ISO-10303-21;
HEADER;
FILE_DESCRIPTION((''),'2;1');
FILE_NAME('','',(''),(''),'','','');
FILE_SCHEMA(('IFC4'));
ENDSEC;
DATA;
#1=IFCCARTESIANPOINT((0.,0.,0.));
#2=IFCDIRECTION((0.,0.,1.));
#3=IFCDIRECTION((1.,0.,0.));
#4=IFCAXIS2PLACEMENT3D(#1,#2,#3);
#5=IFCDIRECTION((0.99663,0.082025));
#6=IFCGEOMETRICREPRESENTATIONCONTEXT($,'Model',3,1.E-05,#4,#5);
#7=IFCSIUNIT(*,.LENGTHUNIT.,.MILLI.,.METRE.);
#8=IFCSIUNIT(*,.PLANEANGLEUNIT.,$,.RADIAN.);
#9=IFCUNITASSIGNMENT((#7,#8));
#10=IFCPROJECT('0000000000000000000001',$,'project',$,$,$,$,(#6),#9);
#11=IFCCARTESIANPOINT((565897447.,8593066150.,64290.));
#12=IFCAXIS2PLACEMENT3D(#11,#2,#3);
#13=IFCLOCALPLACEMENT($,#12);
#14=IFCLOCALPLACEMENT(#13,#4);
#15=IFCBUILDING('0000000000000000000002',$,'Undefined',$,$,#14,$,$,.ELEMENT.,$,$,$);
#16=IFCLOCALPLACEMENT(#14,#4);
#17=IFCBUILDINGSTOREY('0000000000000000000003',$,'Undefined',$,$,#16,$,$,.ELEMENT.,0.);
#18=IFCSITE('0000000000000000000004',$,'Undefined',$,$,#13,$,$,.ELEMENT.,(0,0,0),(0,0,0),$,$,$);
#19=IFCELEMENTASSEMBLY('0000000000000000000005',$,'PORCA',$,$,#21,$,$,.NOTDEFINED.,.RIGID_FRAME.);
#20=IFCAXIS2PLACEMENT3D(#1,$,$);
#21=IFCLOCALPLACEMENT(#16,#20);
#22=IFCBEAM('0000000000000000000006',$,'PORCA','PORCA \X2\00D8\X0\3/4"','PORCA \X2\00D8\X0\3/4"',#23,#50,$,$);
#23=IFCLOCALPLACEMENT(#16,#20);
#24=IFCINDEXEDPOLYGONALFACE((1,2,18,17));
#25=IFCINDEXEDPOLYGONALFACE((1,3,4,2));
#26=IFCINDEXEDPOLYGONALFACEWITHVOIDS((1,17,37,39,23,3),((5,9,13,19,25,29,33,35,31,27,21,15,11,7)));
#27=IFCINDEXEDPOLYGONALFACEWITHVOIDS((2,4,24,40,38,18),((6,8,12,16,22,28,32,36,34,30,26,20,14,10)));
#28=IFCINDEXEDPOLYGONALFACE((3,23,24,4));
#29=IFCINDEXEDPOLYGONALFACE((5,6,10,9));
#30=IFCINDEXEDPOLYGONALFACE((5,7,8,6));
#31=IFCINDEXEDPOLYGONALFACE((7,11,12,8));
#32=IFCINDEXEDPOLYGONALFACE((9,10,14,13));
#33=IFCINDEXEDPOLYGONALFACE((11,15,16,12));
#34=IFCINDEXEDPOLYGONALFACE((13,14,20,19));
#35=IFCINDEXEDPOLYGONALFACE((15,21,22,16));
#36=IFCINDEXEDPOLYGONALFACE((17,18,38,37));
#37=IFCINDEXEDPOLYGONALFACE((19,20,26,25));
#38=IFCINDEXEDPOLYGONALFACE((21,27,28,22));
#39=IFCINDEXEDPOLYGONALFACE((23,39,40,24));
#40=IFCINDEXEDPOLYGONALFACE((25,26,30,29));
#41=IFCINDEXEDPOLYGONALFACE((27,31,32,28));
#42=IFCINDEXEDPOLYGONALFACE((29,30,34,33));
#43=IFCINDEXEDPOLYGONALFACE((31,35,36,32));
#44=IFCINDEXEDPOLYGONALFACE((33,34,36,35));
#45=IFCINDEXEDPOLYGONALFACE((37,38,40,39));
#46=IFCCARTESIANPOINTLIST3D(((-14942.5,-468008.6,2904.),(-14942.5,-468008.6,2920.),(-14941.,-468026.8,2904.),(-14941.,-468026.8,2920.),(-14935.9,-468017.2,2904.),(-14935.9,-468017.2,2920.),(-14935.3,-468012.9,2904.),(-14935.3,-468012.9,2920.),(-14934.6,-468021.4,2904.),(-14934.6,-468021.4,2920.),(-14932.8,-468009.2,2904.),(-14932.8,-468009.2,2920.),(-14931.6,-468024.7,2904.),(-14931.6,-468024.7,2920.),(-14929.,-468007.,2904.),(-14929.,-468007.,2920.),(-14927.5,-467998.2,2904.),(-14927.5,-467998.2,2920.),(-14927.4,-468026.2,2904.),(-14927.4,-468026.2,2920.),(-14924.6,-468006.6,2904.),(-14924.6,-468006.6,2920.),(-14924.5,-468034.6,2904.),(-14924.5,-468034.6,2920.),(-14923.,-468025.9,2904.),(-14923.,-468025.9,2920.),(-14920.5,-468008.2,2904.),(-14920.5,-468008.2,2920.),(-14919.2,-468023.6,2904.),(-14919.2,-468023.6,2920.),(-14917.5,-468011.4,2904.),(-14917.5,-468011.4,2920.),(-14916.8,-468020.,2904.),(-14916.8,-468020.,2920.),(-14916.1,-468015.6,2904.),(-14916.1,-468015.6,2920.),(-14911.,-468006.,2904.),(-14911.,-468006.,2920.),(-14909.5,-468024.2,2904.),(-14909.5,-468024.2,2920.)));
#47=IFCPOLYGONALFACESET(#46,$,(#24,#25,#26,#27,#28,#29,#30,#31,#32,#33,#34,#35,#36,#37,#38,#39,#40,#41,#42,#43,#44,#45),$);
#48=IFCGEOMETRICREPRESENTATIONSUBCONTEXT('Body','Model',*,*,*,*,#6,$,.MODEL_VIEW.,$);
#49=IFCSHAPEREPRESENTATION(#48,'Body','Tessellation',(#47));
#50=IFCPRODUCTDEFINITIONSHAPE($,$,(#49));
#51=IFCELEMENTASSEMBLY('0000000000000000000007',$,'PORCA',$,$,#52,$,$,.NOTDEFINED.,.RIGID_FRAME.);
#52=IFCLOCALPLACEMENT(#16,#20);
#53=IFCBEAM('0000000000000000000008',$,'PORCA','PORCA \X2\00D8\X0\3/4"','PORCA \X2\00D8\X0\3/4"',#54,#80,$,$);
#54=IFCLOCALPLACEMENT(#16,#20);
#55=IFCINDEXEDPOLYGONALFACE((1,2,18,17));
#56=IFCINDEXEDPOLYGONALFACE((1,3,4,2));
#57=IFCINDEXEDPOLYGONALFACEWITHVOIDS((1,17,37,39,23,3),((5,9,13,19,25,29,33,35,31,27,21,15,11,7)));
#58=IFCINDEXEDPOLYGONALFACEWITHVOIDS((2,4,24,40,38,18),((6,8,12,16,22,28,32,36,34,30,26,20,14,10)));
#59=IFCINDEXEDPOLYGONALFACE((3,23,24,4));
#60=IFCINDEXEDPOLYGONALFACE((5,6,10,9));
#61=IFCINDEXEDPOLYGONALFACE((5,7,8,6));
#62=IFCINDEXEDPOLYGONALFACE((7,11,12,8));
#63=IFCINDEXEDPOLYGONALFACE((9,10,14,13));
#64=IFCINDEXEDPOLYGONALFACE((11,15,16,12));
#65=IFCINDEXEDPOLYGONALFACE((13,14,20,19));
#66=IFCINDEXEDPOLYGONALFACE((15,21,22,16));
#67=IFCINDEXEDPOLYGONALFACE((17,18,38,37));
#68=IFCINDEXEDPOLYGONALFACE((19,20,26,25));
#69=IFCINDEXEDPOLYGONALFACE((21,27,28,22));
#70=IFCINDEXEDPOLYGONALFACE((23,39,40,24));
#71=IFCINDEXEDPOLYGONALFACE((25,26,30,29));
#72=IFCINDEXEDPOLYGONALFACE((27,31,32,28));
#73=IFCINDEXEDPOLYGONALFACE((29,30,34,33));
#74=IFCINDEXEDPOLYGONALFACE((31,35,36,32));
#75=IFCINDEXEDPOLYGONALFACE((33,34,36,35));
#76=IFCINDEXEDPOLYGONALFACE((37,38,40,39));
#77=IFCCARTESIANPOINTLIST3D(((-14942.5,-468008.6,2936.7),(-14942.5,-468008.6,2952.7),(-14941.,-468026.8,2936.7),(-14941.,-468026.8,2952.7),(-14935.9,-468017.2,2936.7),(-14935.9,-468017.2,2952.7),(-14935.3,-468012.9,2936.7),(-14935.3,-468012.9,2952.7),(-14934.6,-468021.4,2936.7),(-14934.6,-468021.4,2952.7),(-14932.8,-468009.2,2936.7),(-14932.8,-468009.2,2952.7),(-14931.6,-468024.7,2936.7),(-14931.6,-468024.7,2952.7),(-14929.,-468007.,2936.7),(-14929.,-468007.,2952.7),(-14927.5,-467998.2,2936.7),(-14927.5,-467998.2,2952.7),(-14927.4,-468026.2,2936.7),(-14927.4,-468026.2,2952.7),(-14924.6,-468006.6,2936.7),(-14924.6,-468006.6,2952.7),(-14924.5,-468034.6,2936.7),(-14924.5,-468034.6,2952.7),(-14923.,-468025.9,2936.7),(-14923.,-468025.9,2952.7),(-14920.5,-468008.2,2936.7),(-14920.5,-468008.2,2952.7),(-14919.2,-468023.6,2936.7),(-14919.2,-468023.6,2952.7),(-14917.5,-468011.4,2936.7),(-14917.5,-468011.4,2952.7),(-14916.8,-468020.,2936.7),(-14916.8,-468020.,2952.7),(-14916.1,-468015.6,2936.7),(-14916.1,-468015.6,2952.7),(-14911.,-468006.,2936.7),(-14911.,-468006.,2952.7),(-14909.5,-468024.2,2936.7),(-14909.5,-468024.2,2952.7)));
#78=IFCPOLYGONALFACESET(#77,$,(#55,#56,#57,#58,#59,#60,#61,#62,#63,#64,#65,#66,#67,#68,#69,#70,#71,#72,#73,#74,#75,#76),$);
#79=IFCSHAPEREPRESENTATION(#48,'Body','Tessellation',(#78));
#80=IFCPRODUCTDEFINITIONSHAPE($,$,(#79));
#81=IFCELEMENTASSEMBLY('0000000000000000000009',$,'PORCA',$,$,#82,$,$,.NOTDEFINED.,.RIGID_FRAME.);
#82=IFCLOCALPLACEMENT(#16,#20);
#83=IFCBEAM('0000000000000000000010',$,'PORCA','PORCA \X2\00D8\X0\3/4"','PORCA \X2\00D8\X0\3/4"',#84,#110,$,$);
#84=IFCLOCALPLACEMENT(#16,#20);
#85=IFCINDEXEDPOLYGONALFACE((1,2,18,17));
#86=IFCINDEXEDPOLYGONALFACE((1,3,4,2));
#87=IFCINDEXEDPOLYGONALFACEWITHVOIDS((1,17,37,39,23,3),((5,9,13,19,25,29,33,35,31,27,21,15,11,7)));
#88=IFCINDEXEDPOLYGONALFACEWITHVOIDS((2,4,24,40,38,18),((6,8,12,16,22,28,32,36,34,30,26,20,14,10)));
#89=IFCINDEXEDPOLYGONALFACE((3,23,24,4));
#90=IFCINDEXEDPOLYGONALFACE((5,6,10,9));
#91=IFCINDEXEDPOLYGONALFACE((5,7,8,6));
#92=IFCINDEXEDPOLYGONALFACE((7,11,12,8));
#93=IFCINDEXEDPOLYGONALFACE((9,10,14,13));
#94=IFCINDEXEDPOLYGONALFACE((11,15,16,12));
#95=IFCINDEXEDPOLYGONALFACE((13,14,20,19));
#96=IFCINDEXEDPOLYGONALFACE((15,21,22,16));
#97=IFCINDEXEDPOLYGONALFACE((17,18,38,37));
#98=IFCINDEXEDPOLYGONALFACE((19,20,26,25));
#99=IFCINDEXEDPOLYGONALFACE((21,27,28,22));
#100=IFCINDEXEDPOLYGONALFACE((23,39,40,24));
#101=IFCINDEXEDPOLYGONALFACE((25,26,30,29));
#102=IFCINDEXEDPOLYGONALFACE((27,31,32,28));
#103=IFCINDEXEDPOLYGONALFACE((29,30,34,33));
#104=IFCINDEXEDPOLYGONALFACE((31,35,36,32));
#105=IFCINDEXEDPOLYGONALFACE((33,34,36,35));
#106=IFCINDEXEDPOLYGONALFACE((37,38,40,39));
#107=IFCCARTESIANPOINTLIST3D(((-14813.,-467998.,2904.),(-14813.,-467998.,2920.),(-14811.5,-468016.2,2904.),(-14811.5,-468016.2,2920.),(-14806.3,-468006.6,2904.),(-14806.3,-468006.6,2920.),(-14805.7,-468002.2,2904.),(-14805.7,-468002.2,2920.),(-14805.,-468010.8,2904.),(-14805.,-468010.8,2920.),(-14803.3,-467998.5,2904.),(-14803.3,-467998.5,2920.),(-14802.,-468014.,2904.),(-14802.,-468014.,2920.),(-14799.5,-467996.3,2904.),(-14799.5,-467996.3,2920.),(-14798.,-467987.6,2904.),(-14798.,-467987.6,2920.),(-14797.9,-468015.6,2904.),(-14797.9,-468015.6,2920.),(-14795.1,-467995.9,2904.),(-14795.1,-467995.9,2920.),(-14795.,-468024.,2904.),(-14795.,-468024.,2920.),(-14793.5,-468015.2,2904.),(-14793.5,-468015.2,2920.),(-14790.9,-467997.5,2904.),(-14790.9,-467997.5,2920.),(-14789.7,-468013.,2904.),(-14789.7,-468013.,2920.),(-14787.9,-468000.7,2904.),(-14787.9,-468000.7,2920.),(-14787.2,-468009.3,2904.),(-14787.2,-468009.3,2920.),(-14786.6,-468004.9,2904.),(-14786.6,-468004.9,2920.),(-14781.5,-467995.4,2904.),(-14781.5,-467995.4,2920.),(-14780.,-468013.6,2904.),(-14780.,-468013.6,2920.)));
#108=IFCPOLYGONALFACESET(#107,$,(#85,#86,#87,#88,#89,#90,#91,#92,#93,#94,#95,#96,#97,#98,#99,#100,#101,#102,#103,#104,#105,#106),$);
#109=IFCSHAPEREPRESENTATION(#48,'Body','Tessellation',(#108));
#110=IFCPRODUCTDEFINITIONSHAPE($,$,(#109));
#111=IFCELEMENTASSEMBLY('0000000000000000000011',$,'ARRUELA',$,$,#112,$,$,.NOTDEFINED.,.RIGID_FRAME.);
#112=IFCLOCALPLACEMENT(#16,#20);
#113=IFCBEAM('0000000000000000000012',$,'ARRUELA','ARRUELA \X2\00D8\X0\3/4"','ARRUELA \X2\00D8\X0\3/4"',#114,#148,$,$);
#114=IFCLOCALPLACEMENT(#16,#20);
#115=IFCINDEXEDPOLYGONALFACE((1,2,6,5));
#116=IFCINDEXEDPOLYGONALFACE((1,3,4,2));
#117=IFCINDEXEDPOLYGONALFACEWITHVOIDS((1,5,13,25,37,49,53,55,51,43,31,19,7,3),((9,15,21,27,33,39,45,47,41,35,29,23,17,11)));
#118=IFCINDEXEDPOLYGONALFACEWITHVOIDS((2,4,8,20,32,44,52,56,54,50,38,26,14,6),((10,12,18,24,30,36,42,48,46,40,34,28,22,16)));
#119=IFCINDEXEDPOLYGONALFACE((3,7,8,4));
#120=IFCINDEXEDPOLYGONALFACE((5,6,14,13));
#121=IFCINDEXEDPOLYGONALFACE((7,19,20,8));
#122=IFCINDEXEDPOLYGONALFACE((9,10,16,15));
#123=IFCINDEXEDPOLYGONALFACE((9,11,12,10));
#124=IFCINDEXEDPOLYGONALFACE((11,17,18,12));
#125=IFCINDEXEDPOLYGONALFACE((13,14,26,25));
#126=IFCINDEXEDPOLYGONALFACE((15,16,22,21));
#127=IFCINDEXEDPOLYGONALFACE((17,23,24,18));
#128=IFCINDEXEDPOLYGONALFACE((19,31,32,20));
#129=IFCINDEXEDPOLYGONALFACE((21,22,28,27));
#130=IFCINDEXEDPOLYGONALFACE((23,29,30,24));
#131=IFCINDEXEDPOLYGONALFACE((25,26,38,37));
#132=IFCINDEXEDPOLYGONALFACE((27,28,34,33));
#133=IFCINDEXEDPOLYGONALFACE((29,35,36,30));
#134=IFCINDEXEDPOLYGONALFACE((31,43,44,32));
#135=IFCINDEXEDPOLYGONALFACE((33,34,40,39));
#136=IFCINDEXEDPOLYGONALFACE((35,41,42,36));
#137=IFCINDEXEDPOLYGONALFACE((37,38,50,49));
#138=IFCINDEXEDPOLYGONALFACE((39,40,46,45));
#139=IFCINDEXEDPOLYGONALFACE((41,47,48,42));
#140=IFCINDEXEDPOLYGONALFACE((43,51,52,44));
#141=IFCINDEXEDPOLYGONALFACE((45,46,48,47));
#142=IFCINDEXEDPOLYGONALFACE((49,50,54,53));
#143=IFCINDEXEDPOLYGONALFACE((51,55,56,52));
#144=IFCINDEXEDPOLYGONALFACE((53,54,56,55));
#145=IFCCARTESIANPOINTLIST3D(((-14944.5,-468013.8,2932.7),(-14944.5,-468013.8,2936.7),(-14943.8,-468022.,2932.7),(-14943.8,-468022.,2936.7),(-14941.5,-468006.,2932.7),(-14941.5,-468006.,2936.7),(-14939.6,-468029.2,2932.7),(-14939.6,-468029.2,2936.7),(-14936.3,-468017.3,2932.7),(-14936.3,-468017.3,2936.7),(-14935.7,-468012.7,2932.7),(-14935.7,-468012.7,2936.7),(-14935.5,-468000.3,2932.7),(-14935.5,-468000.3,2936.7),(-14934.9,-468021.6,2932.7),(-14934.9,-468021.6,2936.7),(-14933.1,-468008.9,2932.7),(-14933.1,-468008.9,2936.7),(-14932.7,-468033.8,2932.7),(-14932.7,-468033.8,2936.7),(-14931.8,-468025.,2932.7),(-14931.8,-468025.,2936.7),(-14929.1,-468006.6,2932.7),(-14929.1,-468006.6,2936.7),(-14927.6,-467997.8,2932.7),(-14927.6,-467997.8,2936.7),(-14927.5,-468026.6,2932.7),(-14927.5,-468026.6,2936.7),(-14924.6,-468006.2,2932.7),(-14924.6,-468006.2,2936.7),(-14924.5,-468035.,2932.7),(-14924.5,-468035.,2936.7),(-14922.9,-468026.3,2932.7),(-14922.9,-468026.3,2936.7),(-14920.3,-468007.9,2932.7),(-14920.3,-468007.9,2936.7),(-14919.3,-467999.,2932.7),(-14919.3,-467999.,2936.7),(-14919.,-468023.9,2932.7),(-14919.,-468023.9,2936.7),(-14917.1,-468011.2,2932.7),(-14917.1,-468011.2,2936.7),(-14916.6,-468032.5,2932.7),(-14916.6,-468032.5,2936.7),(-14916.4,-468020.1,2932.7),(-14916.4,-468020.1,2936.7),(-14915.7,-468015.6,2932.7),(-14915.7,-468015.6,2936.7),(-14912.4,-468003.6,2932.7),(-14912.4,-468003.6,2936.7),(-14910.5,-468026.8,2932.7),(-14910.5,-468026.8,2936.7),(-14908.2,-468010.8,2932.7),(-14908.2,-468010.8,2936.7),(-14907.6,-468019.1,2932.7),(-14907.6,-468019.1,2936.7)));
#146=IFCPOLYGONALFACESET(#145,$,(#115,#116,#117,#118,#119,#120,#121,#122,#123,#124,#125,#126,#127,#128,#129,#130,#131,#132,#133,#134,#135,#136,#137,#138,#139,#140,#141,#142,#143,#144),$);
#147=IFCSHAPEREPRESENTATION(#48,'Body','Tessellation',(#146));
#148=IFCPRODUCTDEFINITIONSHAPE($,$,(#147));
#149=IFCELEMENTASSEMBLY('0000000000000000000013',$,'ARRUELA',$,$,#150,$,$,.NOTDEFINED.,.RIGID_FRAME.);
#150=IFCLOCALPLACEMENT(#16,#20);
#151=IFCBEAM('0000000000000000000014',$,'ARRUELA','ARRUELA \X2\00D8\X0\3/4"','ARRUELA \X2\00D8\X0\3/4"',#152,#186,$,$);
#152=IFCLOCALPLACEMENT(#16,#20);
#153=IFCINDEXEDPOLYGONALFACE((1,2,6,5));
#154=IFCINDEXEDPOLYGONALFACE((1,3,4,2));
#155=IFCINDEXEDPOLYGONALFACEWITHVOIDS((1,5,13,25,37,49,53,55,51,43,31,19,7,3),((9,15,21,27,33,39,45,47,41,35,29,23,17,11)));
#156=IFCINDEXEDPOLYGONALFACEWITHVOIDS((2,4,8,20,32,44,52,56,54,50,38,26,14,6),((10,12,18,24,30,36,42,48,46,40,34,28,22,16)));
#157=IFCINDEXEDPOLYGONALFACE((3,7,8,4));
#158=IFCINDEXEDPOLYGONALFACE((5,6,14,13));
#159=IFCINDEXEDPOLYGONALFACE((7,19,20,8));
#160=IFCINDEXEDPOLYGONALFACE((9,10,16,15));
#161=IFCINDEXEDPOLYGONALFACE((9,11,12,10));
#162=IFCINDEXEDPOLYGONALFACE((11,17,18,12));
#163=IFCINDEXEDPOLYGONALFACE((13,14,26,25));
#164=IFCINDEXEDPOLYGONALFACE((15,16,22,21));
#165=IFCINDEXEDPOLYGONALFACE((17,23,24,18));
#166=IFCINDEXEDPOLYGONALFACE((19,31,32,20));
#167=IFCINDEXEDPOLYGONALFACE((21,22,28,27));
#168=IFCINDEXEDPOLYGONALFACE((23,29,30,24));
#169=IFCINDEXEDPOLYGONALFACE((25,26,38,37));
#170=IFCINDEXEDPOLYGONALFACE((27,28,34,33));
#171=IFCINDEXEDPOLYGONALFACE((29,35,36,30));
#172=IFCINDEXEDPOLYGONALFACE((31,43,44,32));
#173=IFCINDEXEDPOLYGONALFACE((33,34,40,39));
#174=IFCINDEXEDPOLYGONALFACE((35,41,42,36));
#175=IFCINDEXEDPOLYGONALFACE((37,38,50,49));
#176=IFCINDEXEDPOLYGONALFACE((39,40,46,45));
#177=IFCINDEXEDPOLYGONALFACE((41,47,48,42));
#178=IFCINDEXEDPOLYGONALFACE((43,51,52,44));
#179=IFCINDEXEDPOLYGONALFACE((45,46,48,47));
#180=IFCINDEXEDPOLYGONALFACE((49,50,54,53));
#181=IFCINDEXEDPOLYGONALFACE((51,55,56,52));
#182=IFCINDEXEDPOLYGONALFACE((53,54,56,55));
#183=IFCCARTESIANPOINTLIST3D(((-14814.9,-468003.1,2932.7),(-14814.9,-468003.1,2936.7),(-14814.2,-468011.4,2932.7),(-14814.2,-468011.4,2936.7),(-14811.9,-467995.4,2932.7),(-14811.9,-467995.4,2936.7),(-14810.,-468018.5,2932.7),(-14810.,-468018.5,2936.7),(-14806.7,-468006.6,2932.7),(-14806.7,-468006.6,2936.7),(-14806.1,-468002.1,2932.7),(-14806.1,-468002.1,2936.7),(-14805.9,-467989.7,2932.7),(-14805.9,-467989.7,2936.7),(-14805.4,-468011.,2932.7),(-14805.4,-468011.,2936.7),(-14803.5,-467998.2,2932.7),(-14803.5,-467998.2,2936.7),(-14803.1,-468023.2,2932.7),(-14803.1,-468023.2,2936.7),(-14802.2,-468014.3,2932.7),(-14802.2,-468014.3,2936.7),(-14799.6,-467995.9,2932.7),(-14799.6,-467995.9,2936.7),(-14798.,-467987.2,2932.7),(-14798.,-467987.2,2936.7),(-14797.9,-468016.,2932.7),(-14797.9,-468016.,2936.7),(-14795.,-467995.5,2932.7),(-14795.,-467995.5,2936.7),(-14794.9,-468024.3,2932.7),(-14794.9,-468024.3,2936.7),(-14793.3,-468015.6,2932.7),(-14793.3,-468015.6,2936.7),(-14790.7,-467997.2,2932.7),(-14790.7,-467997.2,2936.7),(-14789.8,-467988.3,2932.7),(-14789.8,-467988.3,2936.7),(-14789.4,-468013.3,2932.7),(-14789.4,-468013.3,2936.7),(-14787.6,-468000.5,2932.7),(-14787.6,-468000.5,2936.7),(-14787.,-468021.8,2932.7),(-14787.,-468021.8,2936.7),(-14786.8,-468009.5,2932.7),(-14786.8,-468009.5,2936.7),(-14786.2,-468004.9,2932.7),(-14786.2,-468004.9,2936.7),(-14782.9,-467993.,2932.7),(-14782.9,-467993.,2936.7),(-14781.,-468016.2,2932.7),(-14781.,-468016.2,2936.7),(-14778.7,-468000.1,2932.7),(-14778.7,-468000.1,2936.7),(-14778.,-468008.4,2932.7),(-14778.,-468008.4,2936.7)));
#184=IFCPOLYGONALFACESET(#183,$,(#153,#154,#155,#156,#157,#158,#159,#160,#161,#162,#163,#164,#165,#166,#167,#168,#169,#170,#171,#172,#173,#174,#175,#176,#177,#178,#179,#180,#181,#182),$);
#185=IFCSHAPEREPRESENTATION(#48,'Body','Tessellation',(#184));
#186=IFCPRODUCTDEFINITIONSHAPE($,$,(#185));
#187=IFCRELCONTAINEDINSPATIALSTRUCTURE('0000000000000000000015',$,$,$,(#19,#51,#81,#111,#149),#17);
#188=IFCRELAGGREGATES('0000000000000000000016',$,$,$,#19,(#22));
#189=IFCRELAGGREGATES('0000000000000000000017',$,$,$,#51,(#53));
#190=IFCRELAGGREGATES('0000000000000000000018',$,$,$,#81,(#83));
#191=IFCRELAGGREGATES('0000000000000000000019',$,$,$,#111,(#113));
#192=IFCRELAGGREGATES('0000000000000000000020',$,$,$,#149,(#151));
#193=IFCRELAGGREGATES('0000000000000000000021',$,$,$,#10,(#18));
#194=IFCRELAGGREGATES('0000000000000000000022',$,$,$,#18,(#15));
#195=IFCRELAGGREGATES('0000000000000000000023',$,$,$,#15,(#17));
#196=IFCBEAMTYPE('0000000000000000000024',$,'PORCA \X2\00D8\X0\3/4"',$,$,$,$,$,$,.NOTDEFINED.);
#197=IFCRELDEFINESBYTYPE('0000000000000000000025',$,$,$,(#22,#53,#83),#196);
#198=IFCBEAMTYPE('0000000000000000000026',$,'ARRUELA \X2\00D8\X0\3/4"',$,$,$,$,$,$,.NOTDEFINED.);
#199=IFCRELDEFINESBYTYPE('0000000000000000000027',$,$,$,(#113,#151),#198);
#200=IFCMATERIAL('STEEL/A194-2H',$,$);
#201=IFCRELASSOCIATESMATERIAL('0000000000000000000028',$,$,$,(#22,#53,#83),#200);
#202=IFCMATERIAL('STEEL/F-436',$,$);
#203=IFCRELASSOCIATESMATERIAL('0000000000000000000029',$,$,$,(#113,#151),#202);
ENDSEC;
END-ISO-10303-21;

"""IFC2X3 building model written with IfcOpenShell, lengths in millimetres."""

from ifc_helpers import new_model, si_unit, direction, frame, origin_with_axes, place, context, subcontext, project, spatial, polyline, outline, extrude, material, type_object, element, aggregate, save


model = new_model("IFC2X3")

# Units and contexts
model_context = context("Model", 3, precision=1e-05, world=origin_with_axes(), true_north=direction((0.99663, 0.082025)))
body_context = subcontext(model_context, "Body", "Model", "MODEL_VIEW")
ifc_project = project(units=[si_unit("LENGTHUNIT", "METRE", prefix="MILLI"), si_unit("PLANEANGLEUNIT", "RADIAN")], contexts=[model_context])

# Site, building, storey
site_placement = place(None, frame((565897447.0, 8593066150.0, 64290.0), z_axis=(0.0, 0.0, 1.0), x_axis=(1.0, 0.0, 0.0)))
site = spatial("IfcSite", under=ifc_project, at=site_placement, Name="Undefined", CompositionType="ELEMENT", RefLatitude=(0, 0, 0), RefLongitude=(0, 0, 0))
building_placement = place(site_placement, origin_with_axes())
building = spatial("IfcBuilding", under=site, at=building_placement, Name="Undefined", CompositionType="ELEMENT")
storey_placement = place(building_placement, origin_with_axes())
storey = spatial("IfcBuildingStorey", under=building, at=storey_placement, Name="Undefined", CompositionType="ELEMENT", Elevation=0.0)

# Element assemblies, beams
assembly_1_placement = place(storey_placement, origin_with_axes())
assembly_1 = element("IfcElementAssembly", 1, at=assembly_1_placement, inside=storey, Name="PORCA", AssemblyPlace="NOTDEFINED", PredefinedType="RIGID_FRAME")
ifc_material_1 = material(Name="STEEL/A194-2H")
beam_type_1 = type_object("IfcBeamType", Name="PORCA Ø3/4\"", PredefinedType="NOTDEFINED")
beam_1_placement = place(assembly_1_placement, frame((-14926.0, -468016.4, 2920.0), z_axis=(0.99663, 0.082025, 0.0), x_axis=(0.0, 0.0, -1.0)))
beam_1 = element("IfcBeam", 2, at=beam_1_placement, type_object=beam_type_1, material=ifc_material_1, Name="PORCA", Description="PORCA Ø3/4\"", ObjectType="PORCA Ø3/4\"", context=body_context, shape_type="SweptSolid", body=[
    extrude(outline(polyline([(-9.1, 15.8), (9.1, 15.8), (18.3, 0.0), (9.1, -15.8), (-9.1, -15.8), (-18.3, 0.0), (-9.1, 15.8)]), holes=[polyline([(7.8, -6.2), (9.7, -2.2), (9.7, 2.2), (7.8, 6.2), (4.3, 8.9), (0.0, 9.9), (-4.3, 8.9), (-7.8, 6.2), (-9.7, 2.2), (-9.7, -2.2), (-7.8, -6.2), (-4.3, -8.9), (0.0, -9.9), (4.3, -8.9), (7.8, -6.2)])]), frame((16.0, 0.0, 0.0), z_axis=(-1.0, 0.0, 0.0), x_axis=(0.0, -1.0, 0.0)), (0.0, 0.0, 1.0), 16.0),
])
aggregate(assembly_1, [beam_1])
assembly_2_placement = place(storey_placement, origin_with_axes())
assembly_2 = element("IfcElementAssembly", 3, at=assembly_2_placement, inside=storey, Name="PORCA", AssemblyPlace="NOTDEFINED", PredefinedType="RIGID_FRAME")
beam_2_placement = place(assembly_2_placement, frame((-14926.0, -468016.4, 2952.7), z_axis=(0.99663, 0.082025, 0.0), x_axis=(0.0, 0.0, -1.0)))
beam_2 = element("IfcBeam", 4, at=beam_2_placement, type_object=beam_type_1, material=ifc_material_1, Name="PORCA", Description="PORCA Ø3/4\"", ObjectType="PORCA Ø3/4\"", context=body_context, shape_type="SweptSolid", body=[
    extrude(outline(polyline([(-9.1, 15.8), (9.1, 15.8), (18.3, 0.0), (9.1, -15.8), (-9.1, -15.8), (-18.3, 0.0), (-9.1, 15.8)]), holes=[polyline([(7.8, -6.2), (9.7, -2.2), (9.7, 2.2), (7.8, 6.2), (4.3, 8.9), (0.0, 9.9), (-4.3, 8.9), (-7.8, 6.2), (-9.7, 2.2), (-9.7, -2.2), (-7.8, -6.2), (-4.3, -8.9), (0.0, -9.9), (4.3, -8.9), (7.8, -6.2)])]), frame((16.0, 0.0, 0.0), z_axis=(-1.0, 0.0, 0.0), x_axis=(0.0, -1.0, 0.0)), (0.0, 0.0, 1.0), 16.0),
])
aggregate(assembly_2, [beam_2])
assembly_3_placement = place(storey_placement, origin_with_axes())
assembly_3 = element("IfcElementAssembly", 5, at=assembly_3_placement, inside=storey, Name="PORCA", AssemblyPlace="NOTDEFINED", PredefinedType="RIGID_FRAME")
beam_3_placement = place(assembly_3_placement, frame((-14796.5, -468005.8, 2920.0), z_axis=(-0.99663, -0.082025, 0.0), x_axis=(0.0, 0.0, -1.0)))
beam_3 = element("IfcBeam", 6, at=beam_3_placement, type_object=beam_type_1, material=ifc_material_1, Name="PORCA", Description="PORCA Ø3/4\"", ObjectType="PORCA Ø3/4\"", context=body_context, shape_type="SweptSolid", body=[
    extrude(outline(polyline([(-9.1, 15.8), (9.1, 15.8), (18.3, 0.0), (9.1, -15.8), (-9.1, -15.8), (-18.3, 0.0), (-9.1, 15.8)]), holes=[polyline([(7.8, -6.2), (9.7, -2.2), (9.7, 2.2), (7.8, 6.2), (4.3, 8.9), (0.0, 9.9), (-4.3, 8.9), (-7.8, 6.2), (-9.7, 2.2), (-9.7, -2.2), (-7.8, -6.2), (-4.3, -8.9), (0.0, -9.9), (4.3, -8.9), (7.8, -6.2)])]), frame((16.0, 0.0, 0.0), z_axis=(-1.0, 0.0, 0.0), x_axis=(0.0, -1.0, 0.0)), (0.0, 0.0, 1.0), 16.0),
])
aggregate(assembly_3, [beam_3])
assembly_4_placement = place(storey_placement, origin_with_axes())
assembly_4 = element("IfcElementAssembly", 7, at=assembly_4_placement, inside=storey, Name="ARRUELA", AssemblyPlace="NOTDEFINED", PredefinedType="RIGID_FRAME")
ifc_material_2 = material(Name="STEEL/F-436")
beam_type_2 = type_object("IfcBeamType", Name="ARRUELA Ø3/4\"", PredefinedType="NOTDEFINED")
beam_4_placement = place(assembly_4_placement, frame((-14926.0, -468016.4, 2936.7), z_axis=(0.99663, 0.082025, 0.0), x_axis=(0.0, 0.0, -1.0)))
beam_4 = element("IfcBeam", 8, at=beam_4_placement, type_object=beam_type_2, material=ifc_material_2, Name="ARRUELA", Description="ARRUELA Ø3/4\"", ObjectType="ARRUELA Ø3/4\"", context=body_context, shape_type="SweptSolid", body=[
    extrude(outline(polyline([(11.6, 14.6), (16.8, 8.1), (18.6, 0.0), (16.8, -8.1), (11.6, -14.6), (4.2, -18.2), (-4.2, -18.2), (-11.6, -14.6), (-16.8, -8.1), (-18.6, 0.0), (-16.8, 8.1), (-11.6, 14.6), (-4.2, 18.2), (4.2, 18.2), (11.6, 14.6)]), holes=[polyline([(8.1, -6.4), (10.1, -2.3), (10.1, 2.3), (8.1, 6.4), (4.5, 9.3), (0.0, 10.3), (-4.5, 9.3), (-8.1, 6.4), (-10.1, 2.3), (-10.1, -2.3), (-8.1, -6.4), (-4.5, -9.3), (0.0, -10.3), (4.5, -9.3), (8.1, -6.4)])]), frame((4.0, 0.0, 0.0), z_axis=(-1.0, 0.0, 0.0), x_axis=(0.0, -1.0, 0.0)), (0.0, 0.0, 1.0), 4.0),
])
aggregate(assembly_4, [beam_4])
assembly_5_placement = place(storey_placement, origin_with_axes())
assembly_5 = element("IfcElementAssembly", 9, at=assembly_5_placement, inside=storey, Name="ARRUELA", AssemblyPlace="NOTDEFINED", PredefinedType="RIGID_FRAME")
beam_5_placement = place(assembly_5_placement, frame((-14796.5, -468005.8, 2936.7), z_axis=(-0.99663, -0.082025, 0.0), x_axis=(0.0, 0.0, -1.0)))
beam_5 = element("IfcBeam", 10, at=beam_5_placement, type_object=beam_type_2, material=ifc_material_2, Name="ARRUELA", Description="ARRUELA Ø3/4\"", ObjectType="ARRUELA Ø3/4\"", context=body_context, shape_type="SweptSolid", body=[
    extrude(outline(polyline([(11.6, 14.6), (16.8, 8.1), (18.6, 0.0), (16.8, -8.1), (11.6, -14.6), (4.2, -18.2), (-4.2, -18.2), (-11.6, -14.6), (-16.8, -8.1), (-18.6, 0.0), (-16.8, 8.1), (-11.6, 14.6), (-4.2, 18.2), (4.2, 18.2), (11.6, 14.6)]), holes=[polyline([(8.1, -6.4), (10.1, -2.3), (10.1, 2.3), (8.1, 6.4), (4.5, 9.3), (0.0, 10.3), (-4.5, 9.3), (-8.1, 6.4), (-10.1, 2.3), (-10.1, -2.3), (-8.1, -6.4), (-4.5, -9.3), (0.0, -10.3), (4.5, -9.3), (8.1, -6.4)])]), frame((4.0, 0.0, 0.0), z_axis=(-1.0, 0.0, 0.0), x_axis=(0.0, -1.0, 0.0)), (0.0, 0.0, 1.0), 4.0),
])
aggregate(assembly_5, [beam_5])

save(model, "model.ifc")
